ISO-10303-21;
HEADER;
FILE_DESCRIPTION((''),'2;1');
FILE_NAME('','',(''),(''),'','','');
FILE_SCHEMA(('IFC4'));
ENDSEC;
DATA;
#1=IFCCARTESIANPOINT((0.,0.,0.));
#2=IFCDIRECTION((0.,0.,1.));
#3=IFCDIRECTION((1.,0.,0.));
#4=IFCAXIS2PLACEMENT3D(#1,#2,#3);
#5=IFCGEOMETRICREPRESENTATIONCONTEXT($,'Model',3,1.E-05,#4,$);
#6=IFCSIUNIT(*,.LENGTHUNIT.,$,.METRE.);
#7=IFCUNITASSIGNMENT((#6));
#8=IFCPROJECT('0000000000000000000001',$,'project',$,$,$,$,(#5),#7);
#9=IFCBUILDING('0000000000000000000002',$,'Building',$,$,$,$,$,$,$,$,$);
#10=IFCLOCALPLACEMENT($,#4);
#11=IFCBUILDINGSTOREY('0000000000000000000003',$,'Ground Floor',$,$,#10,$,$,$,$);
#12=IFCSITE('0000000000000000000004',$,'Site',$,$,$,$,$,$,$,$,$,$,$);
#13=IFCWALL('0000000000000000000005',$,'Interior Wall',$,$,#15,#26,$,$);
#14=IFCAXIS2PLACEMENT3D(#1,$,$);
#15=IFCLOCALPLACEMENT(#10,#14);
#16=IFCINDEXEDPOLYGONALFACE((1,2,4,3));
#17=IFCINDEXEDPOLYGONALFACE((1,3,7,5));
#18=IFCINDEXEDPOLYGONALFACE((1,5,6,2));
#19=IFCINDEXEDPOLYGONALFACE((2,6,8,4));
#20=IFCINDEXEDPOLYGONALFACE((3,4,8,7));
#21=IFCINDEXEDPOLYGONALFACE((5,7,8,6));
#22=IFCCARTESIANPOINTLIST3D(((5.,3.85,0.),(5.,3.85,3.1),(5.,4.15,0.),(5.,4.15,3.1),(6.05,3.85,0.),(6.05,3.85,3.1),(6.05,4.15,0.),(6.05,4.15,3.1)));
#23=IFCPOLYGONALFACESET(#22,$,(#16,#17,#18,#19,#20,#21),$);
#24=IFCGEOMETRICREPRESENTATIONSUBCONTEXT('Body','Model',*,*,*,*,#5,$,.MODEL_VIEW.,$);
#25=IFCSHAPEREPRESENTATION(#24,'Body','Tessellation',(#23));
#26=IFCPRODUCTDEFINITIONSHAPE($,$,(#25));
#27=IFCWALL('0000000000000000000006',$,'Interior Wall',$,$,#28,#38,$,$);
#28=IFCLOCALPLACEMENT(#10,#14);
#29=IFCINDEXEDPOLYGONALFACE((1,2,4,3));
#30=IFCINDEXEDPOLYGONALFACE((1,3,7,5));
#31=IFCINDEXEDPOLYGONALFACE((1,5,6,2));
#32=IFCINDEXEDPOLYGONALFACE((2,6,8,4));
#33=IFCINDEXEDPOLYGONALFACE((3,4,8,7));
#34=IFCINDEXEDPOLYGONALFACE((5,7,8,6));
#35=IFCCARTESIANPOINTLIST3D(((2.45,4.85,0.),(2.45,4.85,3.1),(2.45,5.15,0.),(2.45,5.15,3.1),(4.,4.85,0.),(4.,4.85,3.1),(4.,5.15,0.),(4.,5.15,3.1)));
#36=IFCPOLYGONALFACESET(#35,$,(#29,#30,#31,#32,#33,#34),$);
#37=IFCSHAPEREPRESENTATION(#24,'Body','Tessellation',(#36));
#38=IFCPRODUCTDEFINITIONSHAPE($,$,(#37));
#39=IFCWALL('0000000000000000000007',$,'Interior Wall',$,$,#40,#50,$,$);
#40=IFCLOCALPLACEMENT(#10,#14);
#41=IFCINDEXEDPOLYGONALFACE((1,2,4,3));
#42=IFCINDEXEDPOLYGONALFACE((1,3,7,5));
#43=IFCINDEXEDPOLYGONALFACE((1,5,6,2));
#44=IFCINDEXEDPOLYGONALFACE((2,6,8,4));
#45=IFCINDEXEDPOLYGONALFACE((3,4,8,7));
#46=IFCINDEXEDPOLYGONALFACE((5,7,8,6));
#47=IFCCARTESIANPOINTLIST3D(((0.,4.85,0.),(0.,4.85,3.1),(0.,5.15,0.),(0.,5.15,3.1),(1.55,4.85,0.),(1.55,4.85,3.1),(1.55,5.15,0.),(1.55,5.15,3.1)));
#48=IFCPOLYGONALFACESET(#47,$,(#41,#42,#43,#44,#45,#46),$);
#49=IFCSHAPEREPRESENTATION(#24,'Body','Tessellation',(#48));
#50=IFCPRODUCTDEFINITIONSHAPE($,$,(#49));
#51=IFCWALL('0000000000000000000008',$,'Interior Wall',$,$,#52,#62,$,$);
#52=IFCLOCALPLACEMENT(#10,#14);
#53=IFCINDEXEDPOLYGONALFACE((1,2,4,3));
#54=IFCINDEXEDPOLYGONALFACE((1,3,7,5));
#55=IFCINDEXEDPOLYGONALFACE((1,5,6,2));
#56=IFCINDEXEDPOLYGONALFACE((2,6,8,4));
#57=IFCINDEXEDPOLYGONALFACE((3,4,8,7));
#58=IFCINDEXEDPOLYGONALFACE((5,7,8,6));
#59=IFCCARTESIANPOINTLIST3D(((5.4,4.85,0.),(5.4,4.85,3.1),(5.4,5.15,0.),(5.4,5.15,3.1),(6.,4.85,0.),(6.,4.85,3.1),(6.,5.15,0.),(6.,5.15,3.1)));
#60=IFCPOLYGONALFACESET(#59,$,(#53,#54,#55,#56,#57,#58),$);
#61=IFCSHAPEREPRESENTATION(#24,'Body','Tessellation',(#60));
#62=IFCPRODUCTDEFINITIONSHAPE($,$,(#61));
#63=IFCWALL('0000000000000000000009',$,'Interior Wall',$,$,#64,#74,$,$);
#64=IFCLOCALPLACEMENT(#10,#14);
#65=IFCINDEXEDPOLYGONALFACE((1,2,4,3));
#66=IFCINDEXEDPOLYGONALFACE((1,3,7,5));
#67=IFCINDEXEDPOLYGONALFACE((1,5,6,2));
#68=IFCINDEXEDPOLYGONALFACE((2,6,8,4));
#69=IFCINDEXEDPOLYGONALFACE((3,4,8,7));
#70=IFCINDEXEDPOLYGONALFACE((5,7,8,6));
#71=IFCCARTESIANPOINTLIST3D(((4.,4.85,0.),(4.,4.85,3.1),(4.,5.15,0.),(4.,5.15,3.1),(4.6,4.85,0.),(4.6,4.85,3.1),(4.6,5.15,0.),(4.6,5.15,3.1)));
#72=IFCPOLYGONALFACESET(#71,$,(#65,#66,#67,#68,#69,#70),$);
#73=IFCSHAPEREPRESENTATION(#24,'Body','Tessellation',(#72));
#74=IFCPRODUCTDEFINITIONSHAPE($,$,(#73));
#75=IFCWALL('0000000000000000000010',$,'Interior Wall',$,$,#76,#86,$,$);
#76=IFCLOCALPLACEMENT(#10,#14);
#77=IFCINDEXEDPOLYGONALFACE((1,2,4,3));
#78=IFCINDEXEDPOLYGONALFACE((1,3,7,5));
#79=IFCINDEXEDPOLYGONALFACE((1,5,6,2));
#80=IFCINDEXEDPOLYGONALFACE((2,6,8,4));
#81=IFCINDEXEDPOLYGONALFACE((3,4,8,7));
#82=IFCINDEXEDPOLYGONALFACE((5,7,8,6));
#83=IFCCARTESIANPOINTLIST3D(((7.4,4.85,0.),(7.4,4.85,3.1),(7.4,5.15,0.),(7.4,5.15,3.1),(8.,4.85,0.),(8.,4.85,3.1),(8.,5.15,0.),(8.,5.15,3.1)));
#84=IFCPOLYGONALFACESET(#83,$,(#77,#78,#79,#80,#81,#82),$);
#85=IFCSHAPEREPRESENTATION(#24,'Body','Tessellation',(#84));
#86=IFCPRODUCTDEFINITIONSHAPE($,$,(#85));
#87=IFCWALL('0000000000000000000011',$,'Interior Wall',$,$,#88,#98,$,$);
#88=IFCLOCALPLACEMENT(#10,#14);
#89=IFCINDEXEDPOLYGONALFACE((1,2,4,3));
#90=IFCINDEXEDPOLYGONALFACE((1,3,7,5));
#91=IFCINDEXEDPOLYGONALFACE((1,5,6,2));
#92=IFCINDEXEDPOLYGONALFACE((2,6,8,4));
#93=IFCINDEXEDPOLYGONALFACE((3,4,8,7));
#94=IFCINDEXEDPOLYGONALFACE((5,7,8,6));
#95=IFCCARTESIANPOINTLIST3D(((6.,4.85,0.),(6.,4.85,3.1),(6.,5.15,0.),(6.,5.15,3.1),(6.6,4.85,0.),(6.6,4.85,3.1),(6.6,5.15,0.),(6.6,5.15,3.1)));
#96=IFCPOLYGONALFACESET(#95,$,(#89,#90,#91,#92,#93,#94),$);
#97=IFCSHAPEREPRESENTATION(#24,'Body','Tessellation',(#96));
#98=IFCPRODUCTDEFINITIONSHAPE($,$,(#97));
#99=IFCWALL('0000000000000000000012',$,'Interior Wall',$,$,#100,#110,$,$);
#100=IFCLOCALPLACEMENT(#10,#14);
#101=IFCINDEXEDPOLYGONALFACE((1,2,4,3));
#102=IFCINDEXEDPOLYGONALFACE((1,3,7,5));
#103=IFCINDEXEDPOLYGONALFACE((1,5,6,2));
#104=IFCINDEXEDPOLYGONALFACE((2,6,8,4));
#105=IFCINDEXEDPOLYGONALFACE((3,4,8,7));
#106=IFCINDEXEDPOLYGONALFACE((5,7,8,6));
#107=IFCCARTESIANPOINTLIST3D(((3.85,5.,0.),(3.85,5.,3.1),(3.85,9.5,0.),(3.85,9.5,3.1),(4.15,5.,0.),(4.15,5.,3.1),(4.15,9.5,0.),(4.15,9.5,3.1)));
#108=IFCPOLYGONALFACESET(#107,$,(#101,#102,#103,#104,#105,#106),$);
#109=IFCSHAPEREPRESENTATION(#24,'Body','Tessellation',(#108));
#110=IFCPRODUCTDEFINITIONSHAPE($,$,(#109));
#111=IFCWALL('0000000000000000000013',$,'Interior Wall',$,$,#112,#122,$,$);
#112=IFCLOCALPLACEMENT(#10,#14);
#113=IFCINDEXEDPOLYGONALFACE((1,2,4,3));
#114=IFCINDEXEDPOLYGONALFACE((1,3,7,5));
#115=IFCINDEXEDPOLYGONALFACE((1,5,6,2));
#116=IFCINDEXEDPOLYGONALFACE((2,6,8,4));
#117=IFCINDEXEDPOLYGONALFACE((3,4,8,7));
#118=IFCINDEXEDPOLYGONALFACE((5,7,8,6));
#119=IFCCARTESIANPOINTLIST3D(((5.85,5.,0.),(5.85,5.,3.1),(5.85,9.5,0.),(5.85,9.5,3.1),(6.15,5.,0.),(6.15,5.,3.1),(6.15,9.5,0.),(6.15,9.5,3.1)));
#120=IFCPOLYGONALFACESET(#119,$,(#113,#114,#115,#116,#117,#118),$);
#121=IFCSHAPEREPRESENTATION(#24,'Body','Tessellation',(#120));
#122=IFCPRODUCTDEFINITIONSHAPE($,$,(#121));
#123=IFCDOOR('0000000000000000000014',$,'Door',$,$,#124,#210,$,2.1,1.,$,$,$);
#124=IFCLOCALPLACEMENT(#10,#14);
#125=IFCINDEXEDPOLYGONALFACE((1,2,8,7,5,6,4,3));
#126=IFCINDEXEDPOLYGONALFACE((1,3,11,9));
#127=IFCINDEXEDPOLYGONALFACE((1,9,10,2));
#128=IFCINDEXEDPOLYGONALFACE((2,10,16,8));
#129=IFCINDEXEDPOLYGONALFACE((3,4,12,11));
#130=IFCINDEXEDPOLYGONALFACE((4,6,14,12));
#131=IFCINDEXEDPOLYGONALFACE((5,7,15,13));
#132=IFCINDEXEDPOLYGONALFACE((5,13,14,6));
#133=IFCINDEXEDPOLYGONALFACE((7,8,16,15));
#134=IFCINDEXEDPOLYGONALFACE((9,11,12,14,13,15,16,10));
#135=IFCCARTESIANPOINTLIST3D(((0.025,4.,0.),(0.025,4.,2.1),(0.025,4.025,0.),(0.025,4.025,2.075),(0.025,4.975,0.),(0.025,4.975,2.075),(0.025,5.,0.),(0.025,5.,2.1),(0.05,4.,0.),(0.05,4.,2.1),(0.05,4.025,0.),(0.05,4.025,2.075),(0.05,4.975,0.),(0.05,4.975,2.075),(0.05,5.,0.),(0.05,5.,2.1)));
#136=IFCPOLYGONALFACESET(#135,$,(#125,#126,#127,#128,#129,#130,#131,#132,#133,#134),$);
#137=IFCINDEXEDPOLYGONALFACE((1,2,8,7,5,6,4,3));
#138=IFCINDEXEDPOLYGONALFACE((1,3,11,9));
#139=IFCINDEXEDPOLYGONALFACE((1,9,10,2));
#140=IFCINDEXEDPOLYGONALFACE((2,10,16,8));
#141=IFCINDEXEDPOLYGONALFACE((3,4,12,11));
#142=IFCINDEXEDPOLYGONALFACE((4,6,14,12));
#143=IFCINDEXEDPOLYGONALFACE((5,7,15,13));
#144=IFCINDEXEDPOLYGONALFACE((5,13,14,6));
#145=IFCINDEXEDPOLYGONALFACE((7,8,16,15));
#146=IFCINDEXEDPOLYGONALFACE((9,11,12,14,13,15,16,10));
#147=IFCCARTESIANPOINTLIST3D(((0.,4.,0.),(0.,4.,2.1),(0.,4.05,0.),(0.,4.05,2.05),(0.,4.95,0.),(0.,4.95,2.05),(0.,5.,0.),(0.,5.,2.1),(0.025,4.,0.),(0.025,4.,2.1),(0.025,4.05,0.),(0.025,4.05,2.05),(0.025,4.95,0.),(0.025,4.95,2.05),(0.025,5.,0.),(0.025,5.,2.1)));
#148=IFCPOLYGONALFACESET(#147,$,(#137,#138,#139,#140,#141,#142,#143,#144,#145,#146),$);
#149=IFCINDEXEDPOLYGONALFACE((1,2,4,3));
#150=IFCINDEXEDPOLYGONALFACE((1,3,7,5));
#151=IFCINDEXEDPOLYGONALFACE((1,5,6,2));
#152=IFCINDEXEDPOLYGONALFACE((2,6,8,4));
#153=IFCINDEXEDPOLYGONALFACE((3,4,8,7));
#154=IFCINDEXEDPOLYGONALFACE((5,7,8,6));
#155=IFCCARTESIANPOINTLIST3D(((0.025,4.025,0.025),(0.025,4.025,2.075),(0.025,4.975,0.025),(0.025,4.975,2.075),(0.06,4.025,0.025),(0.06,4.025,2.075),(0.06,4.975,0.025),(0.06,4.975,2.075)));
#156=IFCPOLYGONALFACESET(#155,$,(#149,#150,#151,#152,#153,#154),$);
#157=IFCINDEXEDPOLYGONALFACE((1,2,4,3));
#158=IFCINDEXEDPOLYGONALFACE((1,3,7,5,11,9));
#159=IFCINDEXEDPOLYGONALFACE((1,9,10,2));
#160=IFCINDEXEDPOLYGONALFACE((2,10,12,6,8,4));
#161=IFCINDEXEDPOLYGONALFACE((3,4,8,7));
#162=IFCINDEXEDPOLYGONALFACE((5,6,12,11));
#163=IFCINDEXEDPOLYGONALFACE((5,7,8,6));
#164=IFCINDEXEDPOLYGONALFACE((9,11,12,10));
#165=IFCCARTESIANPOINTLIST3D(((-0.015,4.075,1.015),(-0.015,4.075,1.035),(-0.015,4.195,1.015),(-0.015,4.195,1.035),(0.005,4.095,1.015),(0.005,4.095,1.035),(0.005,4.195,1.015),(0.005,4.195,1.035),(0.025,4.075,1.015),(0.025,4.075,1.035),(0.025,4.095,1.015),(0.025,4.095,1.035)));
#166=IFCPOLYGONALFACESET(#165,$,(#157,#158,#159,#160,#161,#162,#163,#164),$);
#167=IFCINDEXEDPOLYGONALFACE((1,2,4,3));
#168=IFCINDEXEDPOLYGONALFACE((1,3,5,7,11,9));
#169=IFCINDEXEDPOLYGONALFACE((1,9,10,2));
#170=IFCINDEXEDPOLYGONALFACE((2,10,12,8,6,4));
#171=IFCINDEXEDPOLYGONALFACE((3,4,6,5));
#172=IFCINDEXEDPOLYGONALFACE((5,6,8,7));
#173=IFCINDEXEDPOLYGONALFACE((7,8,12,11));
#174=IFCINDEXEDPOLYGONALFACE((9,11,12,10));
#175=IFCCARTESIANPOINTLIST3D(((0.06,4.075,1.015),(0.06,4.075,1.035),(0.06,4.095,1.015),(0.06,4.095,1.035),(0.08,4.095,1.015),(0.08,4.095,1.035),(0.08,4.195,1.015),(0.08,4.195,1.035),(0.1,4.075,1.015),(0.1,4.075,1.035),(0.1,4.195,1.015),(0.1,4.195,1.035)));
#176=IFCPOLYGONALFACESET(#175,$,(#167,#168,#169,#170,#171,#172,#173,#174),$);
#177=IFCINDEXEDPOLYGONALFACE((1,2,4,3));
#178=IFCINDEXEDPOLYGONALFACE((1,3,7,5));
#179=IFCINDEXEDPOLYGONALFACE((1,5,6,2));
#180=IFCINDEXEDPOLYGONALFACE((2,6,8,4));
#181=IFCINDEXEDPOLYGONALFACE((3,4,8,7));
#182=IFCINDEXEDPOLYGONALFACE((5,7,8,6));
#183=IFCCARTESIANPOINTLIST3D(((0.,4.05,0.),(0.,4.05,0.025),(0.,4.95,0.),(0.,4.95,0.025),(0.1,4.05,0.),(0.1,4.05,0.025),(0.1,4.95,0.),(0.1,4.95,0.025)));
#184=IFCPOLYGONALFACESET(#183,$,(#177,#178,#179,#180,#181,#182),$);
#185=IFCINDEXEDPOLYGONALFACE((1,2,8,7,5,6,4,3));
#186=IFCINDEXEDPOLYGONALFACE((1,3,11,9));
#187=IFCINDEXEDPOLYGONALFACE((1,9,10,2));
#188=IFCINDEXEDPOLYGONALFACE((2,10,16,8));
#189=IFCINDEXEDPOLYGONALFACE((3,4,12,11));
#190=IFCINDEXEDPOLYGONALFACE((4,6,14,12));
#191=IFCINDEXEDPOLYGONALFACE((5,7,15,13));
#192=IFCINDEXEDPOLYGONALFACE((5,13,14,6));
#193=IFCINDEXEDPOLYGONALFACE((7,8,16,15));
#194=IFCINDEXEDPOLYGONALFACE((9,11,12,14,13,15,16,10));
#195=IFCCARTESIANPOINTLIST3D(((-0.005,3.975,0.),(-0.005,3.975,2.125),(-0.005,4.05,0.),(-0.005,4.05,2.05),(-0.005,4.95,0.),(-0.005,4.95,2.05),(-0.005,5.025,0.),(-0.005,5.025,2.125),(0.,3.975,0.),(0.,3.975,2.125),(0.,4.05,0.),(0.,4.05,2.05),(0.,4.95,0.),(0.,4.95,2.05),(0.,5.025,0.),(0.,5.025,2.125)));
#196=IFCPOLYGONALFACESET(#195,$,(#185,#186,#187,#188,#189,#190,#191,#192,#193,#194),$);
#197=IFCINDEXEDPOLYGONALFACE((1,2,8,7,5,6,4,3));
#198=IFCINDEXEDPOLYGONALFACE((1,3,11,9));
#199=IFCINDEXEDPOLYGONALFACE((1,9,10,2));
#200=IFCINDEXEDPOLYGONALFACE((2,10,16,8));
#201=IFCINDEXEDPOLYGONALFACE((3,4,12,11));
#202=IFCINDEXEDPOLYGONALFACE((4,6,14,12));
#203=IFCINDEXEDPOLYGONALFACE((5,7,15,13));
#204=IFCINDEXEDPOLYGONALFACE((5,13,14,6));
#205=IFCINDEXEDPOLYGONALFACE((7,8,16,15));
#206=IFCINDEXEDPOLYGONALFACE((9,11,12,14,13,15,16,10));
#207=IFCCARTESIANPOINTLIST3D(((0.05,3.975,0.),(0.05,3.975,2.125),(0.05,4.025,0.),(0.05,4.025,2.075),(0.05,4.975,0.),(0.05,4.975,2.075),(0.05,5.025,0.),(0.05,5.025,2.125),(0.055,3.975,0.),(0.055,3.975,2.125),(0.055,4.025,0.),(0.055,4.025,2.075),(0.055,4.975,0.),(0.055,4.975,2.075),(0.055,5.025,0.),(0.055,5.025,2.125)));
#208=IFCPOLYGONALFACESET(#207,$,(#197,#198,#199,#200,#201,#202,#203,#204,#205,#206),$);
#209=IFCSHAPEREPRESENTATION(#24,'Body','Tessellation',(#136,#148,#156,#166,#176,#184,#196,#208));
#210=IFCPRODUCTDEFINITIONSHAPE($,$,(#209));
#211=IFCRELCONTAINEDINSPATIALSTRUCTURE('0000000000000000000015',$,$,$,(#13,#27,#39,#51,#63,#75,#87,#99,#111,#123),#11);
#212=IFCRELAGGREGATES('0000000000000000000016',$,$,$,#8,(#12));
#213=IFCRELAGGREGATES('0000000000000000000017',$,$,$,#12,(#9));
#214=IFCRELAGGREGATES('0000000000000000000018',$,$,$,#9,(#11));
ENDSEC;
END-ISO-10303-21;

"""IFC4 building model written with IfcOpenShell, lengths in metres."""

from ifc_helpers import new_model, si_unit, frame, origin_with_axes, place, context, subcontext, project, spatial, line, indexed_curve, outline, extrude, element, save


model = new_model("IFC4")

# Units and contexts
model_context = context("Model", 3, precision=1e-05, world=origin_with_axes())
body_context = subcontext(model_context, "Body", "Model", "MODEL_VIEW")
ifc_project = project(units=[si_unit("LENGTHUNIT", "METRE")], contexts=[model_context])

# Site, building, storey
site = spatial("IfcSite", under=ifc_project, Name="Site")
building = spatial("IfcBuilding", under=site, Name="Building")
storey_placement = place(None, origin_with_axes())
storey = spatial("IfcBuildingStorey", under=building, at=storey_placement, Name="Ground Floor")

# Walls
for number, where, z_axis, x_axis, name in (
    (1, (6.05, 4.0, 0.0), (0.0, 0.0, 1.0), (-1.0, 0.0, 0.0), "Interior Wall"),
):
    element("IfcWall", number, at=place(storey_placement, frame(where, z_axis=z_axis, x_axis=x_axis)), inside=storey, Name=name, context=body_context, shape_type="SweptSolid", body=[
        extrude(outline(indexed_curve([(0.0, 0.0), (0.0, 0.3), (1.05, 0.3), (1.05, 0.0), (0.0, 0.0)], self_intersect=False)), frame((0.0, -0.15, 0.0), z_axis=(0.0, 0.0, 1.0), x_axis=(1.0, 0.0, 0.0)), (0.0, 0.0, 1.0), 3.1),
    ])
for number, where, z_axis, x_axis, name in (
    (2, (4.0, 5.0, 0.0), (0.0, 0.0, 1.0), (-1.0, 0.0, 0.0), "Interior Wall"),
    (3, (1.55, 5.0, 0.0), (0.0, 0.0, 1.0), (-1.0, 0.0, 0.0), "Interior Wall"),
):
    element("IfcWall", number, at=place(storey_placement, frame(where, z_axis=z_axis, x_axis=x_axis)), inside=storey, Name=name, context=body_context, shape_type="SweptSolid", body=[
        extrude(outline(indexed_curve([(0.0, 0.0), (0.0, 0.3), (1.55, 0.3), (1.55, 0.0), (0.0, 0.0)], self_intersect=False)), frame((0.0, -0.15, 0.0), z_axis=(0.0, 0.0, 1.0), x_axis=(1.0, 0.0, 0.0)), (0.0, 0.0, 1.0), 3.1),
    ])
for number, where, z_axis, x_axis, name in (
    (4, (6.0, 5.0, 0.0), (0.0, 0.0, 1.0), (-1.0, 0.0, 0.0), "Interior Wall"),
    (5, (4.6, 5.0, 0.0), (0.0, 0.0, 1.0), (-1.0, 0.0, 0.0), "Interior Wall"),
    (6, (8.0, 5.0, 0.0), (0.0, 0.0, 1.0), (-1.0, 0.0, 0.0), "Interior Wall"),
    (7, (6.6, 5.0, 0.0), (0.0, 0.0, 1.0), (-1.0, 0.0, 0.0), "Interior Wall"),
):
    element("IfcWall", number, at=place(storey_placement, frame(where, z_axis=z_axis, x_axis=x_axis)), inside=storey, Name=name, context=body_context, shape_type="SweptSolid", body=[
        extrude(outline(indexed_curve([(0.0, 0.0), (0.0, 0.3), (0.6, 0.3), (0.6, 0.0), (0.0, 0.0)], self_intersect=False)), frame((0.0, -0.15, 0.0), z_axis=(0.0, 0.0, 1.0), x_axis=(1.0, 0.0, 0.0)), (0.0, 0.0, 1.0), 3.1),
    ])
for number, where, z_axis, x_axis, name in (
    (8, (4.0, 5.0, 0.0), (0.0, 0.0, 1.0), (0.0, 1.0, 0.0), "Interior Wall"),
    (9, (6.0, 5.0, 0.0), (0.0, 0.0, 1.0), (0.0, 1.0, 0.0), "Interior Wall"),
):
    element("IfcWall", number, at=place(storey_placement, frame(where, z_axis=z_axis, x_axis=x_axis)), inside=storey, Name=name, context=body_context, shape_type="SweptSolid", body=[
        extrude(outline(indexed_curve([(0.0, 0.0), (0.0, 0.3), (4.5, 0.3), (4.5, 0.0), (0.0, 0.0)], self_intersect=False)), frame((0.0, -0.15, 0.0), z_axis=(0.0, 0.0, 1.0), x_axis=(1.0, 0.0, 0.0)), (0.0, 0.0, 1.0), 3.1),
    ])

# Door
door_1_placement = place(storey_placement, frame((0.0, 5.0, 0.0), z_axis=(0.0, 0.0, 1.0), x_axis=(0.0, -1.0, 0.0)))
element("IfcDoor", 10, at=door_1_placement, inside=storey, Name="Door", OverallHeight=2.1, OverallWidth=1.0, context=body_context, shape_type="SweptSolid", body=[
    extrude(outline(indexed_curve([(0.0, 0.0), (0.0, 2.1), (1.0, 2.1), (1.0, 0.0), (0.975, 0.0), (0.975, 2.075), (0.025, 2.075), (0.025, 0.0)], segments=[line(1, 2, 3, 4, 5, 6, 7, 8, 1)])), frame((0.0, 0.025, 0.0), z_axis=(0.0, -1.0, 0.0), x_axis=(1.0, 0.0, 0.0)), (0.0, 0.0, -1.0), 0.025),
    extrude(outline(indexed_curve([(0.0, 0.0), (0.0, 2.1), (1.0, 2.1), (1.0, 0.0), (0.95, 0.0), (0.95, 2.05), (0.05, 2.05), (0.05, 0.0)], segments=[line(1, 2, 3, 4, 5, 6, 7, 8, 1)])), frame((0.0, 0.0, 0.0), z_axis=(0.0, -1.0, 0.0), x_axis=(1.0, 0.0, 0.0)), (0.0, 0.0, -1.0), 0.025),
    extrude(outline(indexed_curve([(0.0, 0.0), (0.95, 0.0), (0.95, 0.035), (0.0, 0.035)], segments=[line(1, 2, 3, 4, 1)])), frame((0.025, 0.025, 0.025), z_axis=(0.0, 0.0, 1.0), x_axis=(1.0, 0.0, 0.0)), (0.0, 0.0, 1.0), 2.05),
    extrude(outline(indexed_curve([(0.0, 0.0), (0.0, -0.04), (-0.12, -0.04), (-0.12, -0.02), (-0.02, -0.02), (-0.02, 0.0)], segments=[line(1, 2, 3, 4, 5, 6, 1)])), frame((0.925, 0.025, 1.015), z_axis=(0.0, 0.0, 1.0), x_axis=(1.0, 0.0, 0.0)), (0.0, 0.0, 1.0), 0.02),
    extrude(outline(indexed_curve([(0.0, 0.0), (0.0, 0.04), (-0.12, 0.04), (-0.12, 0.02), (-0.02, 0.02), (-0.02, 0.0)], segments=[line(1, 2, 3, 4, 5, 6, 1)])), frame((0.925, 0.06, 1.015), z_axis=(0.0, 0.0, 1.0), x_axis=(1.0, 0.0, 0.0)), (0.0, 0.0, 1.0), 0.02),
    extrude(outline(indexed_curve([(0.0, 0.0), (0.9, 0.0), (0.9, 0.1), (0.0, 0.1)], segments=[line(1, 2, 3, 4, 1)])), frame((0.05, 0.0, 0.0), z_axis=(0.0, 0.0, 1.0), x_axis=(1.0, 0.0, 0.0)), (0.0, 0.0, 1.0), 0.025),
    extrude(outline(indexed_curve([(0.0, 0.0), (0.0, 2.125), (1.05, 2.125), (1.05, 0.0), (0.975, 0.0), (0.975, 2.05), (0.075, 2.05), (0.075, 0.0)], segments=[line(1, 2, 3, 4, 5, 6, 7, 8, 1)])), frame((-0.025, -0.005, 0.0), z_axis=(0.0, -1.0, 0.0), x_axis=(1.0, 0.0, 0.0)), (0.0, 0.0, -1.0), 0.005),
    extrude(outline(indexed_curve([(0.0, 0.0), (0.0, 2.125), (1.05, 2.125), (1.05, 0.0), (1.0, 0.0), (1.0, 2.075), (0.05, 2.075), (0.05, 0.0)], segments=[line(1, 2, 3, 4, 5, 6, 7, 8, 1)])), frame((-0.025, 0.05, 0.0), z_axis=(0.0, -1.0, 0.0), x_axis=(1.0, 0.0, 0.0)), (0.0, 0.0, -1.0), 0.005),
])

save(model, "model.ifc")
